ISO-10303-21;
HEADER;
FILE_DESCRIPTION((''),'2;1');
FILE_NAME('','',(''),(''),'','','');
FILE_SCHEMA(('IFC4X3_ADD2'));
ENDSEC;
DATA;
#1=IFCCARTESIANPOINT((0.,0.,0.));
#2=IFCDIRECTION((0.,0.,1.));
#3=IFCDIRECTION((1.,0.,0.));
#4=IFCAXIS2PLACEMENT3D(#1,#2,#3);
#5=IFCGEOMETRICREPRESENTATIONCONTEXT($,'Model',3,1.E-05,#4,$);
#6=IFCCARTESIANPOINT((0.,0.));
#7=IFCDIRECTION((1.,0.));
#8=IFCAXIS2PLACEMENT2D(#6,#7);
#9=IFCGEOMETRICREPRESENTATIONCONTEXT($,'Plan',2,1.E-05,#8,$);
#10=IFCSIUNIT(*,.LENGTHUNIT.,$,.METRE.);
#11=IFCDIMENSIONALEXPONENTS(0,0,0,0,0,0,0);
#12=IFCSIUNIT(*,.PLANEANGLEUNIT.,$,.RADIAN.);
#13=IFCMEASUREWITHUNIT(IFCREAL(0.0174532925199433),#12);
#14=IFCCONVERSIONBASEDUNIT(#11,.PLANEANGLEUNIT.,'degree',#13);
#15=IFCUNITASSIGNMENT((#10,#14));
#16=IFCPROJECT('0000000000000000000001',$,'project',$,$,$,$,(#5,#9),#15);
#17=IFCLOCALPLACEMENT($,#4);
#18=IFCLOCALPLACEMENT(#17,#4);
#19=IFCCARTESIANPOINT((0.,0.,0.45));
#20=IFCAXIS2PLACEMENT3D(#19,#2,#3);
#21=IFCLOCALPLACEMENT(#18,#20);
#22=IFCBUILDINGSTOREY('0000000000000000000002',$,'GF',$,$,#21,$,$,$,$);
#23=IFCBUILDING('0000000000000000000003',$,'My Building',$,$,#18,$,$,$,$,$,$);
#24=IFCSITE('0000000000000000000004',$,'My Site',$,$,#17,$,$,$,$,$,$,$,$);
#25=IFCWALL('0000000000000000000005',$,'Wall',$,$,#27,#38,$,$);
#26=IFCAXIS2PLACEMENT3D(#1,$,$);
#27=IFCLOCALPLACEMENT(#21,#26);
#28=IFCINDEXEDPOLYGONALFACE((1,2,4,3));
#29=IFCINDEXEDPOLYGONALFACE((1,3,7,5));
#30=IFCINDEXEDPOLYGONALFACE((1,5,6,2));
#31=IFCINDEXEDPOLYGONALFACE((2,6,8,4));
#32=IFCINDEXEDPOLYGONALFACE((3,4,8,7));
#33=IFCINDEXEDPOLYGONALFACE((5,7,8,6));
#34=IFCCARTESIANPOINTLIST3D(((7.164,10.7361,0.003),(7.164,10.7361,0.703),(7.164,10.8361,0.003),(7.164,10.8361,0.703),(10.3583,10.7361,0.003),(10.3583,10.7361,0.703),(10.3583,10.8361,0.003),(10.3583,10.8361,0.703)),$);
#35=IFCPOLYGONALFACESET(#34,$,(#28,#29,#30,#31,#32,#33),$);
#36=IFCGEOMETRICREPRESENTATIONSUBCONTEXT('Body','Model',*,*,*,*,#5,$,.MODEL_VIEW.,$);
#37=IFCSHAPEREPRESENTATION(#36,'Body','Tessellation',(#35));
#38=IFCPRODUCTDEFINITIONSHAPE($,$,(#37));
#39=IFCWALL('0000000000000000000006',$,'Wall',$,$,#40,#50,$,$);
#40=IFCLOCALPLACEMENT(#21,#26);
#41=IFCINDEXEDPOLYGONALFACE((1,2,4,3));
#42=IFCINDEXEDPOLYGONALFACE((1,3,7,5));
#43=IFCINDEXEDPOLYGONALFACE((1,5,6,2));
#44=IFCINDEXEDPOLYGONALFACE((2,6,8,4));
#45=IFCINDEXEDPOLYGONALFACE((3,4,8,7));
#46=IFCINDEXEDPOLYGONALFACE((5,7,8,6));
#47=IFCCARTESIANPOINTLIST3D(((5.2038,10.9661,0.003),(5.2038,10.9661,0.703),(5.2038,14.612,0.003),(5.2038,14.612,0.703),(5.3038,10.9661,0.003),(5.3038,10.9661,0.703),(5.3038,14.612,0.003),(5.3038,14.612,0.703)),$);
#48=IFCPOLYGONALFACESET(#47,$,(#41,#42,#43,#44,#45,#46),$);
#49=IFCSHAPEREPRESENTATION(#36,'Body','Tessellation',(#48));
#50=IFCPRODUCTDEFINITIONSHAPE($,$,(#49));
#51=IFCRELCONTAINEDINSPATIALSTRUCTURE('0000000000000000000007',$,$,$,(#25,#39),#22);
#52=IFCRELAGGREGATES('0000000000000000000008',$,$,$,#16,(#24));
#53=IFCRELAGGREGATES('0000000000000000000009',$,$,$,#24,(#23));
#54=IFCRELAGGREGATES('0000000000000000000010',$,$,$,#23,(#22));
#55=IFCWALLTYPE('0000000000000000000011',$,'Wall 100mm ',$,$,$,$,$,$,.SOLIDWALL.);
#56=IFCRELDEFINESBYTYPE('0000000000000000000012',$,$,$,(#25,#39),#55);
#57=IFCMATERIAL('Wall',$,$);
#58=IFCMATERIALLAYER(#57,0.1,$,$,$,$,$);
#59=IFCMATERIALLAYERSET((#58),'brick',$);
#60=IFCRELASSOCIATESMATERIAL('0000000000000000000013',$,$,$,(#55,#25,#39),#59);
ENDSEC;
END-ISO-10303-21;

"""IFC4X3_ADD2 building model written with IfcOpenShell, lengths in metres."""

from ifc_helpers import new_model, entity, si_unit, converted_unit, frame, origin_with_axes, origin_2d_with_axis, place, context, subcontext, project, spatial, indexed_curve, outline, extrude, material, layer, layer_set, layer_usage, type_object, element, save


model = new_model("IFC4X3_ADD2")

# Units and contexts
model_context = context("Model", 3, precision=1e-05, world=origin_with_axes())
plan_context = context("Plan", 2, precision=1e-05, world=origin_2d_with_axis())
body_context_1 = subcontext(model_context, "Body", "Model", "MODEL_VIEW")
ifc_project = project(units=[si_unit("LENGTHUNIT", "METRE"), converted_unit("PLANEANGLEUNIT", "degree", entity("IfcReal", 0.0174532925199433), si_unit("PLANEANGLEUNIT", "RADIAN"), dimensions=[0, 0, 0, 0, 0, 0, 0])], contexts=[model_context, plan_context])

# Site, building, storey
site_placement = place(None, origin_with_axes())
site = spatial("IfcSite", under=ifc_project, at=site_placement, Name="My Site")
building_placement = place(site_placement, origin_with_axes())
building = spatial("IfcBuilding", under=site, at=building_placement, Name="My Building")
storey_placement = place(building_placement, frame((0.0, 0.0, 0.45), z_axis=(0.0, 0.0, 1.0), x_axis=(1.0, 0.0, 0.0)))
storey = spatial("IfcBuildingStorey", under=building, at=storey_placement, Name="GF")

# Shared definitions
ifc_material_1 = material(Name="Wall")

# Walls
ifc_layer_1 = layer(ifc_material_1, 0.1)
ifc_layer_set_1 = layer_set([ifc_layer_1], Name="brick")
ifc_layer_usage_1 = layer_usage(ifc_layer_set_1, "AXIS2", "POSITIVE", 0.0)
wall_type_1 = type_object("IfcWallType", Name="Wall 100mm ", PredefinedType="SOLIDWALL", material=ifc_layer_set_1)
wall_1_placement = place(storey_placement, frame((7.164, 10.7361, 0.003), z_axis=(0.0, 0.0, 1.0), x_axis=(1.0, 0.0, 0.0)))
element("IfcWall", 1, at=wall_1_placement, inside=storey, type_object=wall_type_1, material=ifc_layer_usage_1, Name="Wall", context=body_context_1, shape_type="SweptSolid", body=[
    extrude(outline(indexed_curve([(0.0, 0.0), (0.0, 0.1), (3.1943, 0.1), (3.1943, 0.0), (0.0, 0.0)], self_intersect=False)), origin_with_axes(), (0.0, 0.0, 1.0), 0.7),
])
ifc_layer_usage_2 = layer_usage(ifc_layer_set_1, "AXIS2", "POSITIVE", 0.0)
wall_2_placement = place(storey_placement, frame((5.2038, 14.612, 0.003), z_axis=(0.0, 0.0, 1.0), x_axis=(0.0, -1.0, 0.0)))
element("IfcWall", 2, at=wall_2_placement, inside=storey, type_object=wall_type_1, material=ifc_layer_usage_2, Name="Wall", context=body_context_1, shape_type="SweptSolid", body=[
    extrude(outline(indexed_curve([(0.0, 0.0), (0.0, 0.1), (3.6459, 0.1), (3.6459, 0.0), (0.0, 0.0)], self_intersect=False)), origin_with_axes(), (0.0, 0.0, 1.0), 0.7),
])

save(model, "model.ifc")
